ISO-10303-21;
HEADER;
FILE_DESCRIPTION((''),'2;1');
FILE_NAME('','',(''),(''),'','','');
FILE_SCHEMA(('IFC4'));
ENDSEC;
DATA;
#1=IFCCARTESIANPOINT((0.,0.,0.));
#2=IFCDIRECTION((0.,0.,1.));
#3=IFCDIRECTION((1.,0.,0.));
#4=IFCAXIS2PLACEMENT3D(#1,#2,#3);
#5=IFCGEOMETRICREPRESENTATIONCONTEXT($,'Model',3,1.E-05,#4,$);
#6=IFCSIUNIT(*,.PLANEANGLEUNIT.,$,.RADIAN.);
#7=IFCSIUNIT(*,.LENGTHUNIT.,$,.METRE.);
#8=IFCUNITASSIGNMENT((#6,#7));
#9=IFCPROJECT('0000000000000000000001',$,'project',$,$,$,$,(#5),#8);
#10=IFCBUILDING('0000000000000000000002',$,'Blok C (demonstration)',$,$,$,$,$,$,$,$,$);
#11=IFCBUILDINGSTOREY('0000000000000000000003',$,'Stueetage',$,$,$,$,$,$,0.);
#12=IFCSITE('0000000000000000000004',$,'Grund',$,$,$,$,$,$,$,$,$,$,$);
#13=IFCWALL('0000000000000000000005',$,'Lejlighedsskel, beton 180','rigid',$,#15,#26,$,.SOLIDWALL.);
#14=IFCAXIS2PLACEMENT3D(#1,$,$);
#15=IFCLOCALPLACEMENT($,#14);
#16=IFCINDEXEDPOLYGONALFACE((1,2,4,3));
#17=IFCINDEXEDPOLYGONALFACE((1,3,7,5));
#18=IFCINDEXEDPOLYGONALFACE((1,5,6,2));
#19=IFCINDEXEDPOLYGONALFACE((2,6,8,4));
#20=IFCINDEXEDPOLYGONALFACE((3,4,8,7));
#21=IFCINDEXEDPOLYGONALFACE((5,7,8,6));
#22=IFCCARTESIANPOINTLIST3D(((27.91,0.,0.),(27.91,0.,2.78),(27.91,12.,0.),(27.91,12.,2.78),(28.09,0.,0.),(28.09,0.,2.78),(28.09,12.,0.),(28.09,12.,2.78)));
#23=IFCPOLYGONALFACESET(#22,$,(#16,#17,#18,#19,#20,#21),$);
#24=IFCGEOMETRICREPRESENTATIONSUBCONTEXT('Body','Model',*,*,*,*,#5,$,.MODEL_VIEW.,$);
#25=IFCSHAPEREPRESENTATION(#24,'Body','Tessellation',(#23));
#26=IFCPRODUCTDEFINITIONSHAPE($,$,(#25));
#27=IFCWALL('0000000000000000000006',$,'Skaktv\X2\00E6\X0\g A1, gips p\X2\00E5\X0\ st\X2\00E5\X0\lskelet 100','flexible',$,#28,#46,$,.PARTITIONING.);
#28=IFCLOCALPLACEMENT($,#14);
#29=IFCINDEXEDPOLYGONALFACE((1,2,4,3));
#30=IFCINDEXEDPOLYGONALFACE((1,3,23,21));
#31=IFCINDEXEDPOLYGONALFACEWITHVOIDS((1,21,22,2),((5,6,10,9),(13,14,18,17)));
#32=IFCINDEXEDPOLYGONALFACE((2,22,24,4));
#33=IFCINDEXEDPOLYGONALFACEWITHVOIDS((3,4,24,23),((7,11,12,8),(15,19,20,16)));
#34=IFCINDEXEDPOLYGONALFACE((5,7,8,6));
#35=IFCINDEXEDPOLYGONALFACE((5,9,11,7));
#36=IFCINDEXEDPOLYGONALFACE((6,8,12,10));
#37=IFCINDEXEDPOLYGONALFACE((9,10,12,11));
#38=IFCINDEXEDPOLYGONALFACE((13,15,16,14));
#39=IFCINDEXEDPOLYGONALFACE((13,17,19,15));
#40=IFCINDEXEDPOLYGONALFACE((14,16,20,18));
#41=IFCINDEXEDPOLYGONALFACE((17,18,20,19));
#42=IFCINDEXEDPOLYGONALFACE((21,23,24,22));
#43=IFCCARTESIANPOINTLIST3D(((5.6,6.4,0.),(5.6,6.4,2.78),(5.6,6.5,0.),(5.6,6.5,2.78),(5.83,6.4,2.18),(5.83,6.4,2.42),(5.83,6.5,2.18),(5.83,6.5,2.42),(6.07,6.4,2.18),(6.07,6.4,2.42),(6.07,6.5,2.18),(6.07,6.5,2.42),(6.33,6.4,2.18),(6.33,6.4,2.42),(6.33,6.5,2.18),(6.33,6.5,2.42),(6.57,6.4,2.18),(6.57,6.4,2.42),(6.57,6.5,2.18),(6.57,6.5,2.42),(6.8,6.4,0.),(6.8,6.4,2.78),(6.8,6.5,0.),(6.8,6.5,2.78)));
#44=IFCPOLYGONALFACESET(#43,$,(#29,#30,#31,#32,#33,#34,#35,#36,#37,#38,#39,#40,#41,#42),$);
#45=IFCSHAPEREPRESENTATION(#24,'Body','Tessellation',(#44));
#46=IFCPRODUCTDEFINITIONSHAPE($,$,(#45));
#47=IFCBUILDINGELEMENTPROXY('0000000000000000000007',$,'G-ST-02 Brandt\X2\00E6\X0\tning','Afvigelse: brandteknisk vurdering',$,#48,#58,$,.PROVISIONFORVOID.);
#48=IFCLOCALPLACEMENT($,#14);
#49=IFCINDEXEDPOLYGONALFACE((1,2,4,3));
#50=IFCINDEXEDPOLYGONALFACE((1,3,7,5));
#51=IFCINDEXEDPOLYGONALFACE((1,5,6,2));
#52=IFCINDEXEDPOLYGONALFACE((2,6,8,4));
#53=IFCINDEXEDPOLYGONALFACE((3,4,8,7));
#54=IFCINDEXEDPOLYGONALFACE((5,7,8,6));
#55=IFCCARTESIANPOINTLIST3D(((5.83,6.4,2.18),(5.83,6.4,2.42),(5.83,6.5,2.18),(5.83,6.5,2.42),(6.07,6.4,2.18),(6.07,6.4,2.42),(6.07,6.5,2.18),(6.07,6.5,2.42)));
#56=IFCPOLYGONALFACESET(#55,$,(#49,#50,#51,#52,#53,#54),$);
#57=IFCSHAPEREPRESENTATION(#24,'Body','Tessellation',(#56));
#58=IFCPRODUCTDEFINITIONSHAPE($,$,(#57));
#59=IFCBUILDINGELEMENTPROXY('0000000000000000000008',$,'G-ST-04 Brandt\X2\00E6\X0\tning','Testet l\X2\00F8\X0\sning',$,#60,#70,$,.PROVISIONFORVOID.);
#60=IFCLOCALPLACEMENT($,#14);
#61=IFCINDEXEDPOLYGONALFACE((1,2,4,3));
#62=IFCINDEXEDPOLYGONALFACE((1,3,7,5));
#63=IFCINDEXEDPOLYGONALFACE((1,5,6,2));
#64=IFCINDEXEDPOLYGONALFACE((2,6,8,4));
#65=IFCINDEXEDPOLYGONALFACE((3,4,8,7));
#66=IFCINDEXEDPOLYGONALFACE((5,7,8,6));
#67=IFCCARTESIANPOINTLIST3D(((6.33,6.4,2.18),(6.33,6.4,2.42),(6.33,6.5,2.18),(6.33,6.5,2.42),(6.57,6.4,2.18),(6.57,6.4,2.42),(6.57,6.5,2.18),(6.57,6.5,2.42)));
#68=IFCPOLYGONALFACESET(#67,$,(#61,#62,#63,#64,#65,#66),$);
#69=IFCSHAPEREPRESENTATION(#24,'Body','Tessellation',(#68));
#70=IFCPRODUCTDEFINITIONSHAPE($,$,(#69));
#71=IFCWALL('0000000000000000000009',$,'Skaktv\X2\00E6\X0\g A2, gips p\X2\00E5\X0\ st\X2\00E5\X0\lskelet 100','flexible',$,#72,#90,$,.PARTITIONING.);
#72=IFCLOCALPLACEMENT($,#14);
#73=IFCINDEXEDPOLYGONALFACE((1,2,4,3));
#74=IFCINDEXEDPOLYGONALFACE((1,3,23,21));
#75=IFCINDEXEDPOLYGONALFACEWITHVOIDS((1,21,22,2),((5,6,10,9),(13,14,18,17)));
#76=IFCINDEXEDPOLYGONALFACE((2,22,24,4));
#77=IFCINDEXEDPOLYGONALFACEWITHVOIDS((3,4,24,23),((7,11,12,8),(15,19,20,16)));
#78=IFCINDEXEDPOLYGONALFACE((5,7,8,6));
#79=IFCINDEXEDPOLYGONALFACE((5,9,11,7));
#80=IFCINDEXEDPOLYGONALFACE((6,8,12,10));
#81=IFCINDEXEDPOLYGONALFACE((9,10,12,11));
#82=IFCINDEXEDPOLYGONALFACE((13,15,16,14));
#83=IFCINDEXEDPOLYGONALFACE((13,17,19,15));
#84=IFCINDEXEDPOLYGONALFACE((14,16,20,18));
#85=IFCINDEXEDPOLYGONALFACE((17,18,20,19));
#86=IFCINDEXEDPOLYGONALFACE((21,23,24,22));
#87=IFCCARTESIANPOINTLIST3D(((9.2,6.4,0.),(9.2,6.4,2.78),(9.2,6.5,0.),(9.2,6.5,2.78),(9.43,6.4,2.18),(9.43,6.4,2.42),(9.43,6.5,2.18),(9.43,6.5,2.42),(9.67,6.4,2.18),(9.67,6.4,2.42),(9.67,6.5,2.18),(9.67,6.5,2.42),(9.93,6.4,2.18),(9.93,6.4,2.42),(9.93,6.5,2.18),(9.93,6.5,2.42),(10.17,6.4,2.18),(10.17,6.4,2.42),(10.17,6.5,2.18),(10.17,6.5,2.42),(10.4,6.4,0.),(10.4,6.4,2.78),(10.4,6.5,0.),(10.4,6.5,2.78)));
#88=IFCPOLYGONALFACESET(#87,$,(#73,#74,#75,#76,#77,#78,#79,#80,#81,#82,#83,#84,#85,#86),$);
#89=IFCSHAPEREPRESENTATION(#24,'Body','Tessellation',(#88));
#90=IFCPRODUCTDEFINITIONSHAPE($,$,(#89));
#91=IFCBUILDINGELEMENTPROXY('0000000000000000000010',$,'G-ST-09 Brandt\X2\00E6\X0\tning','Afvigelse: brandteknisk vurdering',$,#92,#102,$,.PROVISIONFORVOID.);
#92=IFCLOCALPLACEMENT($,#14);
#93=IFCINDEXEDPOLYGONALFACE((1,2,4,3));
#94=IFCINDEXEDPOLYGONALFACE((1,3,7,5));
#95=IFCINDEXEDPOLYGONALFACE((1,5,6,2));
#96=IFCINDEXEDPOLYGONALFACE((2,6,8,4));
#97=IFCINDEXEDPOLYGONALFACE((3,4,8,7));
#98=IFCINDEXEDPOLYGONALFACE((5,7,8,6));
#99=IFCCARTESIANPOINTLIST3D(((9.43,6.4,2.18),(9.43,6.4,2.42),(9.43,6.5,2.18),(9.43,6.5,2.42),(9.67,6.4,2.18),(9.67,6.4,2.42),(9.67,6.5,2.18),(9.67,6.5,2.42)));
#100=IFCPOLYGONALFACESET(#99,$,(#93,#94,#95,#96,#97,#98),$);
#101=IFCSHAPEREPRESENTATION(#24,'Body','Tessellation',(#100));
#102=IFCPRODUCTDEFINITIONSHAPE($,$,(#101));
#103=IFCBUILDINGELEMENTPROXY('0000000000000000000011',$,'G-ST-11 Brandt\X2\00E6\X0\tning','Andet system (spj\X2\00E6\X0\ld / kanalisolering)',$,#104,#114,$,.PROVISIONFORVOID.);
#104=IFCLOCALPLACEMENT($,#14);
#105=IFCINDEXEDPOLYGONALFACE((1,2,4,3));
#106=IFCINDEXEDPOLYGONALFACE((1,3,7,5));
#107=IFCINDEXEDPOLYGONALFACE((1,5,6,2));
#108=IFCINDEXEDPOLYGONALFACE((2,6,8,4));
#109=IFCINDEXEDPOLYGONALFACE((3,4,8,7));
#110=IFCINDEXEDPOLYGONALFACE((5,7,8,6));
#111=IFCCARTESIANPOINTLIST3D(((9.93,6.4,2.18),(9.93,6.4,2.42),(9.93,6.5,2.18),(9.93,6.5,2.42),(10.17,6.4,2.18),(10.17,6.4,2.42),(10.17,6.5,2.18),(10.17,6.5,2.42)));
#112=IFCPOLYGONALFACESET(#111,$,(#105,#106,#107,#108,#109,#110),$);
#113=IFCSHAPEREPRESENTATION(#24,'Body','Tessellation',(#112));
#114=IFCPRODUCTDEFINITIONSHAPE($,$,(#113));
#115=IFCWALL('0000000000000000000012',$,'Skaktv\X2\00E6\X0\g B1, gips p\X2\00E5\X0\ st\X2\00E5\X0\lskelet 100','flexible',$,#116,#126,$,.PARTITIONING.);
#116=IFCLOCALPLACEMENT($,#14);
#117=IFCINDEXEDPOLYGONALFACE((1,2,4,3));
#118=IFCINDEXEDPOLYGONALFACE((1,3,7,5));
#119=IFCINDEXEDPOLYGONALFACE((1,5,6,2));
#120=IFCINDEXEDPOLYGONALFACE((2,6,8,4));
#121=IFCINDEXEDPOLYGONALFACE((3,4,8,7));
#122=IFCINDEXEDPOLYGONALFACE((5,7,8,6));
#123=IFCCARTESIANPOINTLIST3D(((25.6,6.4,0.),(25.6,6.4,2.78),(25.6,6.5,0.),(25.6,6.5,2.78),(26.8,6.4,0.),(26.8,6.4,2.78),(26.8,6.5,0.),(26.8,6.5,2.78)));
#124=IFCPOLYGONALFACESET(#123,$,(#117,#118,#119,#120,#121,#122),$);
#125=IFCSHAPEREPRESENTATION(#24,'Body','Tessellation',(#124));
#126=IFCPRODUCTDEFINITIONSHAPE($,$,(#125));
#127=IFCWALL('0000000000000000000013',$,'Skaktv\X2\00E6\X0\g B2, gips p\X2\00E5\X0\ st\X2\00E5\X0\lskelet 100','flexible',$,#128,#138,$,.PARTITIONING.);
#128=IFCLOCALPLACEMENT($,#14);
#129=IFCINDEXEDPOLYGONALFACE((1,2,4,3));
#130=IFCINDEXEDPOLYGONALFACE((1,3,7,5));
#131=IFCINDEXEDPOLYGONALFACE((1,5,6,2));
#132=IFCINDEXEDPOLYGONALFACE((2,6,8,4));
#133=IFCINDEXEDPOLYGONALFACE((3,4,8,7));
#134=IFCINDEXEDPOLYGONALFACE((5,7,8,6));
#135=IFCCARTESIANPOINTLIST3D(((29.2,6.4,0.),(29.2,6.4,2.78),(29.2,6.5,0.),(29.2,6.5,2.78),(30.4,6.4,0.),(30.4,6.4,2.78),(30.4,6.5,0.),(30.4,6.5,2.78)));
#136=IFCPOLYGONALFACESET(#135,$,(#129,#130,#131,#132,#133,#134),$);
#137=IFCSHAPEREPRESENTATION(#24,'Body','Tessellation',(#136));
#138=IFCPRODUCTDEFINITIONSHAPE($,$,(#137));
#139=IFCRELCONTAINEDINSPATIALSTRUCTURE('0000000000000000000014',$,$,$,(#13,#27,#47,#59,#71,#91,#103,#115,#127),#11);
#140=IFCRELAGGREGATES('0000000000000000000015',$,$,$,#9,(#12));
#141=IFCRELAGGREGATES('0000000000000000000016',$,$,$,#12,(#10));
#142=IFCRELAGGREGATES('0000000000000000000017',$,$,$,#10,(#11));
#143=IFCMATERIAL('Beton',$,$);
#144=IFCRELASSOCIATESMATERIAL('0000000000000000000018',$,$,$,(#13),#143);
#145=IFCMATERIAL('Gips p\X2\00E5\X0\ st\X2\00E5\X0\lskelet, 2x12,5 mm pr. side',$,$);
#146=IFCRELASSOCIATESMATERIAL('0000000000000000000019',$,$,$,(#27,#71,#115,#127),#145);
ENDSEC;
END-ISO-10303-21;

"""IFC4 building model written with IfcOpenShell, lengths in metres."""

from ifc_helpers import new_model, si_unit, frame, origin, origin_with_axes, place, context, subcontext, project, spatial, polyline, outline, extrude, material, element, fill, save


model = new_model("IFC4")

# Units and contexts
model_context = context("Model", 3, precision=1e-05, world=origin_with_axes())
body_context = subcontext(model_context, "Body", "Model", "MODEL_VIEW")
ifc_project = project(units=[si_unit("PLANEANGLEUNIT", "RADIAN"), si_unit("LENGTHUNIT", "METRE")], contexts=[model_context])

# Site, building, storey
site = spatial("IfcSite", under=ifc_project, Name="Grund")
building = spatial("IfcBuilding", under=site, Name="Blok C (demonstration)")
storey = spatial("IfcBuildingStorey", under=building, Name="Stueetage", Elevation=0.0)

# Wall
ifc_material_1 = material(Name="Beton")
wall_1_placement = place(None, origin_with_axes())
element("IfcWall", 1, at=wall_1_placement, inside=storey, material=ifc_material_1, Name="Lejlighedsskel, beton 180", Description="rigid", PredefinedType="SOLIDWALL", context=body_context, shape_type="SweptSolid", body=[
    extrude(outline(polyline([(27.91, 0.0), (28.09, 0.0), (28.09, 12.0), (27.91, 12.0), (27.91, 0.0)])), origin(), (0.0, 0.0, 1.0), 2.78),
])

# Walls, openings, building element proxies
ifc_material_2 = material(Name="Gips på stålskelet, 2x12,5 mm pr. side")
wall_2_placement = place(None, origin_with_axes())
wall_2 = element("IfcWall", 2, at=wall_2_placement, inside=storey, material=ifc_material_2, Name="Skaktvæg A1, gips på stålskelet 100", Description="flexible", PredefinedType="PARTITIONING", context=body_context, shape_type="SweptSolid", body=[
    extrude(outline(polyline([(5.6, 6.4), (6.8, 6.4), (6.8, 6.5), (5.6, 6.5), (5.6, 6.4)])), origin(), (0.0, 0.0, 1.0), 2.78),
])
opening_1_placement = place(wall_2_placement, origin_with_axes())
opening_1 = element("IfcOpeningElement", 3, at=opening_1_placement, cuts=wall_2, PredefinedType="OPENING", context=body_context, shape_type="SweptSolid", body=[
    extrude(outline(polyline([(5.83, 6.33), (6.07, 6.33), (6.07, 6.57), (5.83, 6.57), (5.83, 6.33)])), frame((0.0, 0.0, 2.18)), (0.0, 0.0, 1.0), 0.24),
])
opening_2_placement = place(wall_2_placement, origin_with_axes())
opening_2 = element("IfcOpeningElement", 4, at=opening_2_placement, cuts=wall_2, PredefinedType="OPENING", context=body_context, shape_type="SweptSolid", body=[
    extrude(outline(polyline([(6.33, 6.33), (6.57, 6.33), (6.57, 6.57), (6.33, 6.57), (6.33, 6.33)])), frame((0.0, 0.0, 2.18)), (0.0, 0.0, 1.0), 0.24),
])
proxy_1_placement = place(None, origin_with_axes())
proxy_1 = element("IfcBuildingElementProxy", 5, at=proxy_1_placement, inside=storey, Name="G-ST-02 Brandtætning", Description="Afvigelse: brandteknisk vurdering", PredefinedType="PROVISIONFORVOID", context=body_context, shape_type="SweptSolid", body=[
    extrude(outline(polyline([(5.83, 6.4), (6.07, 6.4), (6.07, 6.5), (5.83, 6.5), (5.83, 6.4)])), frame((0.0, 0.0, 2.18)), (0.0, 0.0, 1.0), 0.24),
])
fill(opening_1, proxy_1)
proxy_2_placement = place(None, origin_with_axes())
proxy_2 = element("IfcBuildingElementProxy", 6, at=proxy_2_placement, inside=storey, Name="G-ST-04 Brandtætning", Description="Testet løsning", PredefinedType="PROVISIONFORVOID", context=body_context, shape_type="SweptSolid", body=[
    extrude(outline(polyline([(6.33, 6.4), (6.57, 6.4), (6.57, 6.5), (6.33, 6.5), (6.33, 6.4)])), frame((0.0, 0.0, 2.18)), (0.0, 0.0, 1.0), 0.24),
])
fill(opening_2, proxy_2)
wall_3_placement = place(None, origin_with_axes())
wall_3 = element("IfcWall", 7, at=wall_3_placement, inside=storey, material=ifc_material_2, Name="Skaktvæg A2, gips på stålskelet 100", Description="flexible", PredefinedType="PARTITIONING", context=body_context, shape_type="SweptSolid", body=[
    extrude(outline(polyline([(9.2, 6.4), (10.4, 6.4), (10.4, 6.5), (9.2, 6.5), (9.2, 6.4)])), origin(), (0.0, 0.0, 1.0), 2.78),
])
opening_3_placement = place(wall_3_placement, origin_with_axes())
opening_3 = element("IfcOpeningElement", 8, at=opening_3_placement, cuts=wall_3, PredefinedType="OPENING", context=body_context, shape_type="SweptSolid", body=[
    extrude(outline(polyline([(9.43, 6.33), (9.67, 6.33), (9.67, 6.57), (9.43, 6.57), (9.43, 6.33)])), frame((0.0, 0.0, 2.18)), (0.0, 0.0, 1.0), 0.24),
])
opening_4_placement = place(wall_3_placement, origin_with_axes())
opening_4 = element("IfcOpeningElement", 9, at=opening_4_placement, cuts=wall_3, PredefinedType="OPENING", context=body_context, shape_type="SweptSolid", body=[
    extrude(outline(polyline([(9.93, 6.33), (10.17, 6.33), (10.17, 6.57), (9.93, 6.57), (9.93, 6.33)])), frame((0.0, 0.0, 2.18)), (0.0, 0.0, 1.0), 0.24),
])
proxy_3_placement = place(None, origin_with_axes())
proxy_3 = element("IfcBuildingElementProxy", 10, at=proxy_3_placement, inside=storey, Name="G-ST-09 Brandtætning", Description="Afvigelse: brandteknisk vurdering", PredefinedType="PROVISIONFORVOID", context=body_context, shape_type="SweptSolid", body=[
    extrude(outline(polyline([(9.43, 6.4), (9.67, 6.4), (9.67, 6.5), (9.43, 6.5), (9.43, 6.4)])), frame((0.0, 0.0, 2.18)), (0.0, 0.0, 1.0), 0.24),
])
fill(opening_3, proxy_3)
proxy_4_placement = place(None, origin_with_axes())
proxy_4 = element("IfcBuildingElementProxy", 11, at=proxy_4_placement, inside=storey, Name="G-ST-11 Brandtætning", Description="Andet system (spjæld / kanalisolering)", PredefinedType="PROVISIONFORVOID", context=body_context, shape_type="SweptSolid", body=[
    extrude(outline(polyline([(9.93, 6.4), (10.17, 6.4), (10.17, 6.5), (9.93, 6.5), (9.93, 6.4)])), frame((0.0, 0.0, 2.18)), (0.0, 0.0, 1.0), 0.24),
])
fill(opening_4, proxy_4)

# Walls
wall_4_placement = place(None, origin_with_axes())
element("IfcWall", 12, at=wall_4_placement, inside=storey, material=ifc_material_2, Name="Skaktvæg B1, gips på stålskelet 100", Description="flexible", PredefinedType="PARTITIONING", context=body_context, shape_type="SweptSolid", body=[
    extrude(outline(polyline([(25.6, 6.4), (26.8, 6.4), (26.8, 6.5), (25.6, 6.5), (25.6, 6.4)])), origin(), (0.0, 0.0, 1.0), 2.78),
])
wall_5_placement = place(None, origin_with_axes())
element("IfcWall", 13, at=wall_5_placement, inside=storey, material=ifc_material_2, Name="Skaktvæg B2, gips på stålskelet 100", Description="flexible", PredefinedType="PARTITIONING", context=body_context, shape_type="SweptSolid", body=[
    extrude(outline(polyline([(29.2, 6.4), (30.4, 6.4), (30.4, 6.5), (29.2, 6.5), (29.2, 6.4)])), origin(), (0.0, 0.0, 1.0), 2.78),
])

save(model, "model.ifc")
